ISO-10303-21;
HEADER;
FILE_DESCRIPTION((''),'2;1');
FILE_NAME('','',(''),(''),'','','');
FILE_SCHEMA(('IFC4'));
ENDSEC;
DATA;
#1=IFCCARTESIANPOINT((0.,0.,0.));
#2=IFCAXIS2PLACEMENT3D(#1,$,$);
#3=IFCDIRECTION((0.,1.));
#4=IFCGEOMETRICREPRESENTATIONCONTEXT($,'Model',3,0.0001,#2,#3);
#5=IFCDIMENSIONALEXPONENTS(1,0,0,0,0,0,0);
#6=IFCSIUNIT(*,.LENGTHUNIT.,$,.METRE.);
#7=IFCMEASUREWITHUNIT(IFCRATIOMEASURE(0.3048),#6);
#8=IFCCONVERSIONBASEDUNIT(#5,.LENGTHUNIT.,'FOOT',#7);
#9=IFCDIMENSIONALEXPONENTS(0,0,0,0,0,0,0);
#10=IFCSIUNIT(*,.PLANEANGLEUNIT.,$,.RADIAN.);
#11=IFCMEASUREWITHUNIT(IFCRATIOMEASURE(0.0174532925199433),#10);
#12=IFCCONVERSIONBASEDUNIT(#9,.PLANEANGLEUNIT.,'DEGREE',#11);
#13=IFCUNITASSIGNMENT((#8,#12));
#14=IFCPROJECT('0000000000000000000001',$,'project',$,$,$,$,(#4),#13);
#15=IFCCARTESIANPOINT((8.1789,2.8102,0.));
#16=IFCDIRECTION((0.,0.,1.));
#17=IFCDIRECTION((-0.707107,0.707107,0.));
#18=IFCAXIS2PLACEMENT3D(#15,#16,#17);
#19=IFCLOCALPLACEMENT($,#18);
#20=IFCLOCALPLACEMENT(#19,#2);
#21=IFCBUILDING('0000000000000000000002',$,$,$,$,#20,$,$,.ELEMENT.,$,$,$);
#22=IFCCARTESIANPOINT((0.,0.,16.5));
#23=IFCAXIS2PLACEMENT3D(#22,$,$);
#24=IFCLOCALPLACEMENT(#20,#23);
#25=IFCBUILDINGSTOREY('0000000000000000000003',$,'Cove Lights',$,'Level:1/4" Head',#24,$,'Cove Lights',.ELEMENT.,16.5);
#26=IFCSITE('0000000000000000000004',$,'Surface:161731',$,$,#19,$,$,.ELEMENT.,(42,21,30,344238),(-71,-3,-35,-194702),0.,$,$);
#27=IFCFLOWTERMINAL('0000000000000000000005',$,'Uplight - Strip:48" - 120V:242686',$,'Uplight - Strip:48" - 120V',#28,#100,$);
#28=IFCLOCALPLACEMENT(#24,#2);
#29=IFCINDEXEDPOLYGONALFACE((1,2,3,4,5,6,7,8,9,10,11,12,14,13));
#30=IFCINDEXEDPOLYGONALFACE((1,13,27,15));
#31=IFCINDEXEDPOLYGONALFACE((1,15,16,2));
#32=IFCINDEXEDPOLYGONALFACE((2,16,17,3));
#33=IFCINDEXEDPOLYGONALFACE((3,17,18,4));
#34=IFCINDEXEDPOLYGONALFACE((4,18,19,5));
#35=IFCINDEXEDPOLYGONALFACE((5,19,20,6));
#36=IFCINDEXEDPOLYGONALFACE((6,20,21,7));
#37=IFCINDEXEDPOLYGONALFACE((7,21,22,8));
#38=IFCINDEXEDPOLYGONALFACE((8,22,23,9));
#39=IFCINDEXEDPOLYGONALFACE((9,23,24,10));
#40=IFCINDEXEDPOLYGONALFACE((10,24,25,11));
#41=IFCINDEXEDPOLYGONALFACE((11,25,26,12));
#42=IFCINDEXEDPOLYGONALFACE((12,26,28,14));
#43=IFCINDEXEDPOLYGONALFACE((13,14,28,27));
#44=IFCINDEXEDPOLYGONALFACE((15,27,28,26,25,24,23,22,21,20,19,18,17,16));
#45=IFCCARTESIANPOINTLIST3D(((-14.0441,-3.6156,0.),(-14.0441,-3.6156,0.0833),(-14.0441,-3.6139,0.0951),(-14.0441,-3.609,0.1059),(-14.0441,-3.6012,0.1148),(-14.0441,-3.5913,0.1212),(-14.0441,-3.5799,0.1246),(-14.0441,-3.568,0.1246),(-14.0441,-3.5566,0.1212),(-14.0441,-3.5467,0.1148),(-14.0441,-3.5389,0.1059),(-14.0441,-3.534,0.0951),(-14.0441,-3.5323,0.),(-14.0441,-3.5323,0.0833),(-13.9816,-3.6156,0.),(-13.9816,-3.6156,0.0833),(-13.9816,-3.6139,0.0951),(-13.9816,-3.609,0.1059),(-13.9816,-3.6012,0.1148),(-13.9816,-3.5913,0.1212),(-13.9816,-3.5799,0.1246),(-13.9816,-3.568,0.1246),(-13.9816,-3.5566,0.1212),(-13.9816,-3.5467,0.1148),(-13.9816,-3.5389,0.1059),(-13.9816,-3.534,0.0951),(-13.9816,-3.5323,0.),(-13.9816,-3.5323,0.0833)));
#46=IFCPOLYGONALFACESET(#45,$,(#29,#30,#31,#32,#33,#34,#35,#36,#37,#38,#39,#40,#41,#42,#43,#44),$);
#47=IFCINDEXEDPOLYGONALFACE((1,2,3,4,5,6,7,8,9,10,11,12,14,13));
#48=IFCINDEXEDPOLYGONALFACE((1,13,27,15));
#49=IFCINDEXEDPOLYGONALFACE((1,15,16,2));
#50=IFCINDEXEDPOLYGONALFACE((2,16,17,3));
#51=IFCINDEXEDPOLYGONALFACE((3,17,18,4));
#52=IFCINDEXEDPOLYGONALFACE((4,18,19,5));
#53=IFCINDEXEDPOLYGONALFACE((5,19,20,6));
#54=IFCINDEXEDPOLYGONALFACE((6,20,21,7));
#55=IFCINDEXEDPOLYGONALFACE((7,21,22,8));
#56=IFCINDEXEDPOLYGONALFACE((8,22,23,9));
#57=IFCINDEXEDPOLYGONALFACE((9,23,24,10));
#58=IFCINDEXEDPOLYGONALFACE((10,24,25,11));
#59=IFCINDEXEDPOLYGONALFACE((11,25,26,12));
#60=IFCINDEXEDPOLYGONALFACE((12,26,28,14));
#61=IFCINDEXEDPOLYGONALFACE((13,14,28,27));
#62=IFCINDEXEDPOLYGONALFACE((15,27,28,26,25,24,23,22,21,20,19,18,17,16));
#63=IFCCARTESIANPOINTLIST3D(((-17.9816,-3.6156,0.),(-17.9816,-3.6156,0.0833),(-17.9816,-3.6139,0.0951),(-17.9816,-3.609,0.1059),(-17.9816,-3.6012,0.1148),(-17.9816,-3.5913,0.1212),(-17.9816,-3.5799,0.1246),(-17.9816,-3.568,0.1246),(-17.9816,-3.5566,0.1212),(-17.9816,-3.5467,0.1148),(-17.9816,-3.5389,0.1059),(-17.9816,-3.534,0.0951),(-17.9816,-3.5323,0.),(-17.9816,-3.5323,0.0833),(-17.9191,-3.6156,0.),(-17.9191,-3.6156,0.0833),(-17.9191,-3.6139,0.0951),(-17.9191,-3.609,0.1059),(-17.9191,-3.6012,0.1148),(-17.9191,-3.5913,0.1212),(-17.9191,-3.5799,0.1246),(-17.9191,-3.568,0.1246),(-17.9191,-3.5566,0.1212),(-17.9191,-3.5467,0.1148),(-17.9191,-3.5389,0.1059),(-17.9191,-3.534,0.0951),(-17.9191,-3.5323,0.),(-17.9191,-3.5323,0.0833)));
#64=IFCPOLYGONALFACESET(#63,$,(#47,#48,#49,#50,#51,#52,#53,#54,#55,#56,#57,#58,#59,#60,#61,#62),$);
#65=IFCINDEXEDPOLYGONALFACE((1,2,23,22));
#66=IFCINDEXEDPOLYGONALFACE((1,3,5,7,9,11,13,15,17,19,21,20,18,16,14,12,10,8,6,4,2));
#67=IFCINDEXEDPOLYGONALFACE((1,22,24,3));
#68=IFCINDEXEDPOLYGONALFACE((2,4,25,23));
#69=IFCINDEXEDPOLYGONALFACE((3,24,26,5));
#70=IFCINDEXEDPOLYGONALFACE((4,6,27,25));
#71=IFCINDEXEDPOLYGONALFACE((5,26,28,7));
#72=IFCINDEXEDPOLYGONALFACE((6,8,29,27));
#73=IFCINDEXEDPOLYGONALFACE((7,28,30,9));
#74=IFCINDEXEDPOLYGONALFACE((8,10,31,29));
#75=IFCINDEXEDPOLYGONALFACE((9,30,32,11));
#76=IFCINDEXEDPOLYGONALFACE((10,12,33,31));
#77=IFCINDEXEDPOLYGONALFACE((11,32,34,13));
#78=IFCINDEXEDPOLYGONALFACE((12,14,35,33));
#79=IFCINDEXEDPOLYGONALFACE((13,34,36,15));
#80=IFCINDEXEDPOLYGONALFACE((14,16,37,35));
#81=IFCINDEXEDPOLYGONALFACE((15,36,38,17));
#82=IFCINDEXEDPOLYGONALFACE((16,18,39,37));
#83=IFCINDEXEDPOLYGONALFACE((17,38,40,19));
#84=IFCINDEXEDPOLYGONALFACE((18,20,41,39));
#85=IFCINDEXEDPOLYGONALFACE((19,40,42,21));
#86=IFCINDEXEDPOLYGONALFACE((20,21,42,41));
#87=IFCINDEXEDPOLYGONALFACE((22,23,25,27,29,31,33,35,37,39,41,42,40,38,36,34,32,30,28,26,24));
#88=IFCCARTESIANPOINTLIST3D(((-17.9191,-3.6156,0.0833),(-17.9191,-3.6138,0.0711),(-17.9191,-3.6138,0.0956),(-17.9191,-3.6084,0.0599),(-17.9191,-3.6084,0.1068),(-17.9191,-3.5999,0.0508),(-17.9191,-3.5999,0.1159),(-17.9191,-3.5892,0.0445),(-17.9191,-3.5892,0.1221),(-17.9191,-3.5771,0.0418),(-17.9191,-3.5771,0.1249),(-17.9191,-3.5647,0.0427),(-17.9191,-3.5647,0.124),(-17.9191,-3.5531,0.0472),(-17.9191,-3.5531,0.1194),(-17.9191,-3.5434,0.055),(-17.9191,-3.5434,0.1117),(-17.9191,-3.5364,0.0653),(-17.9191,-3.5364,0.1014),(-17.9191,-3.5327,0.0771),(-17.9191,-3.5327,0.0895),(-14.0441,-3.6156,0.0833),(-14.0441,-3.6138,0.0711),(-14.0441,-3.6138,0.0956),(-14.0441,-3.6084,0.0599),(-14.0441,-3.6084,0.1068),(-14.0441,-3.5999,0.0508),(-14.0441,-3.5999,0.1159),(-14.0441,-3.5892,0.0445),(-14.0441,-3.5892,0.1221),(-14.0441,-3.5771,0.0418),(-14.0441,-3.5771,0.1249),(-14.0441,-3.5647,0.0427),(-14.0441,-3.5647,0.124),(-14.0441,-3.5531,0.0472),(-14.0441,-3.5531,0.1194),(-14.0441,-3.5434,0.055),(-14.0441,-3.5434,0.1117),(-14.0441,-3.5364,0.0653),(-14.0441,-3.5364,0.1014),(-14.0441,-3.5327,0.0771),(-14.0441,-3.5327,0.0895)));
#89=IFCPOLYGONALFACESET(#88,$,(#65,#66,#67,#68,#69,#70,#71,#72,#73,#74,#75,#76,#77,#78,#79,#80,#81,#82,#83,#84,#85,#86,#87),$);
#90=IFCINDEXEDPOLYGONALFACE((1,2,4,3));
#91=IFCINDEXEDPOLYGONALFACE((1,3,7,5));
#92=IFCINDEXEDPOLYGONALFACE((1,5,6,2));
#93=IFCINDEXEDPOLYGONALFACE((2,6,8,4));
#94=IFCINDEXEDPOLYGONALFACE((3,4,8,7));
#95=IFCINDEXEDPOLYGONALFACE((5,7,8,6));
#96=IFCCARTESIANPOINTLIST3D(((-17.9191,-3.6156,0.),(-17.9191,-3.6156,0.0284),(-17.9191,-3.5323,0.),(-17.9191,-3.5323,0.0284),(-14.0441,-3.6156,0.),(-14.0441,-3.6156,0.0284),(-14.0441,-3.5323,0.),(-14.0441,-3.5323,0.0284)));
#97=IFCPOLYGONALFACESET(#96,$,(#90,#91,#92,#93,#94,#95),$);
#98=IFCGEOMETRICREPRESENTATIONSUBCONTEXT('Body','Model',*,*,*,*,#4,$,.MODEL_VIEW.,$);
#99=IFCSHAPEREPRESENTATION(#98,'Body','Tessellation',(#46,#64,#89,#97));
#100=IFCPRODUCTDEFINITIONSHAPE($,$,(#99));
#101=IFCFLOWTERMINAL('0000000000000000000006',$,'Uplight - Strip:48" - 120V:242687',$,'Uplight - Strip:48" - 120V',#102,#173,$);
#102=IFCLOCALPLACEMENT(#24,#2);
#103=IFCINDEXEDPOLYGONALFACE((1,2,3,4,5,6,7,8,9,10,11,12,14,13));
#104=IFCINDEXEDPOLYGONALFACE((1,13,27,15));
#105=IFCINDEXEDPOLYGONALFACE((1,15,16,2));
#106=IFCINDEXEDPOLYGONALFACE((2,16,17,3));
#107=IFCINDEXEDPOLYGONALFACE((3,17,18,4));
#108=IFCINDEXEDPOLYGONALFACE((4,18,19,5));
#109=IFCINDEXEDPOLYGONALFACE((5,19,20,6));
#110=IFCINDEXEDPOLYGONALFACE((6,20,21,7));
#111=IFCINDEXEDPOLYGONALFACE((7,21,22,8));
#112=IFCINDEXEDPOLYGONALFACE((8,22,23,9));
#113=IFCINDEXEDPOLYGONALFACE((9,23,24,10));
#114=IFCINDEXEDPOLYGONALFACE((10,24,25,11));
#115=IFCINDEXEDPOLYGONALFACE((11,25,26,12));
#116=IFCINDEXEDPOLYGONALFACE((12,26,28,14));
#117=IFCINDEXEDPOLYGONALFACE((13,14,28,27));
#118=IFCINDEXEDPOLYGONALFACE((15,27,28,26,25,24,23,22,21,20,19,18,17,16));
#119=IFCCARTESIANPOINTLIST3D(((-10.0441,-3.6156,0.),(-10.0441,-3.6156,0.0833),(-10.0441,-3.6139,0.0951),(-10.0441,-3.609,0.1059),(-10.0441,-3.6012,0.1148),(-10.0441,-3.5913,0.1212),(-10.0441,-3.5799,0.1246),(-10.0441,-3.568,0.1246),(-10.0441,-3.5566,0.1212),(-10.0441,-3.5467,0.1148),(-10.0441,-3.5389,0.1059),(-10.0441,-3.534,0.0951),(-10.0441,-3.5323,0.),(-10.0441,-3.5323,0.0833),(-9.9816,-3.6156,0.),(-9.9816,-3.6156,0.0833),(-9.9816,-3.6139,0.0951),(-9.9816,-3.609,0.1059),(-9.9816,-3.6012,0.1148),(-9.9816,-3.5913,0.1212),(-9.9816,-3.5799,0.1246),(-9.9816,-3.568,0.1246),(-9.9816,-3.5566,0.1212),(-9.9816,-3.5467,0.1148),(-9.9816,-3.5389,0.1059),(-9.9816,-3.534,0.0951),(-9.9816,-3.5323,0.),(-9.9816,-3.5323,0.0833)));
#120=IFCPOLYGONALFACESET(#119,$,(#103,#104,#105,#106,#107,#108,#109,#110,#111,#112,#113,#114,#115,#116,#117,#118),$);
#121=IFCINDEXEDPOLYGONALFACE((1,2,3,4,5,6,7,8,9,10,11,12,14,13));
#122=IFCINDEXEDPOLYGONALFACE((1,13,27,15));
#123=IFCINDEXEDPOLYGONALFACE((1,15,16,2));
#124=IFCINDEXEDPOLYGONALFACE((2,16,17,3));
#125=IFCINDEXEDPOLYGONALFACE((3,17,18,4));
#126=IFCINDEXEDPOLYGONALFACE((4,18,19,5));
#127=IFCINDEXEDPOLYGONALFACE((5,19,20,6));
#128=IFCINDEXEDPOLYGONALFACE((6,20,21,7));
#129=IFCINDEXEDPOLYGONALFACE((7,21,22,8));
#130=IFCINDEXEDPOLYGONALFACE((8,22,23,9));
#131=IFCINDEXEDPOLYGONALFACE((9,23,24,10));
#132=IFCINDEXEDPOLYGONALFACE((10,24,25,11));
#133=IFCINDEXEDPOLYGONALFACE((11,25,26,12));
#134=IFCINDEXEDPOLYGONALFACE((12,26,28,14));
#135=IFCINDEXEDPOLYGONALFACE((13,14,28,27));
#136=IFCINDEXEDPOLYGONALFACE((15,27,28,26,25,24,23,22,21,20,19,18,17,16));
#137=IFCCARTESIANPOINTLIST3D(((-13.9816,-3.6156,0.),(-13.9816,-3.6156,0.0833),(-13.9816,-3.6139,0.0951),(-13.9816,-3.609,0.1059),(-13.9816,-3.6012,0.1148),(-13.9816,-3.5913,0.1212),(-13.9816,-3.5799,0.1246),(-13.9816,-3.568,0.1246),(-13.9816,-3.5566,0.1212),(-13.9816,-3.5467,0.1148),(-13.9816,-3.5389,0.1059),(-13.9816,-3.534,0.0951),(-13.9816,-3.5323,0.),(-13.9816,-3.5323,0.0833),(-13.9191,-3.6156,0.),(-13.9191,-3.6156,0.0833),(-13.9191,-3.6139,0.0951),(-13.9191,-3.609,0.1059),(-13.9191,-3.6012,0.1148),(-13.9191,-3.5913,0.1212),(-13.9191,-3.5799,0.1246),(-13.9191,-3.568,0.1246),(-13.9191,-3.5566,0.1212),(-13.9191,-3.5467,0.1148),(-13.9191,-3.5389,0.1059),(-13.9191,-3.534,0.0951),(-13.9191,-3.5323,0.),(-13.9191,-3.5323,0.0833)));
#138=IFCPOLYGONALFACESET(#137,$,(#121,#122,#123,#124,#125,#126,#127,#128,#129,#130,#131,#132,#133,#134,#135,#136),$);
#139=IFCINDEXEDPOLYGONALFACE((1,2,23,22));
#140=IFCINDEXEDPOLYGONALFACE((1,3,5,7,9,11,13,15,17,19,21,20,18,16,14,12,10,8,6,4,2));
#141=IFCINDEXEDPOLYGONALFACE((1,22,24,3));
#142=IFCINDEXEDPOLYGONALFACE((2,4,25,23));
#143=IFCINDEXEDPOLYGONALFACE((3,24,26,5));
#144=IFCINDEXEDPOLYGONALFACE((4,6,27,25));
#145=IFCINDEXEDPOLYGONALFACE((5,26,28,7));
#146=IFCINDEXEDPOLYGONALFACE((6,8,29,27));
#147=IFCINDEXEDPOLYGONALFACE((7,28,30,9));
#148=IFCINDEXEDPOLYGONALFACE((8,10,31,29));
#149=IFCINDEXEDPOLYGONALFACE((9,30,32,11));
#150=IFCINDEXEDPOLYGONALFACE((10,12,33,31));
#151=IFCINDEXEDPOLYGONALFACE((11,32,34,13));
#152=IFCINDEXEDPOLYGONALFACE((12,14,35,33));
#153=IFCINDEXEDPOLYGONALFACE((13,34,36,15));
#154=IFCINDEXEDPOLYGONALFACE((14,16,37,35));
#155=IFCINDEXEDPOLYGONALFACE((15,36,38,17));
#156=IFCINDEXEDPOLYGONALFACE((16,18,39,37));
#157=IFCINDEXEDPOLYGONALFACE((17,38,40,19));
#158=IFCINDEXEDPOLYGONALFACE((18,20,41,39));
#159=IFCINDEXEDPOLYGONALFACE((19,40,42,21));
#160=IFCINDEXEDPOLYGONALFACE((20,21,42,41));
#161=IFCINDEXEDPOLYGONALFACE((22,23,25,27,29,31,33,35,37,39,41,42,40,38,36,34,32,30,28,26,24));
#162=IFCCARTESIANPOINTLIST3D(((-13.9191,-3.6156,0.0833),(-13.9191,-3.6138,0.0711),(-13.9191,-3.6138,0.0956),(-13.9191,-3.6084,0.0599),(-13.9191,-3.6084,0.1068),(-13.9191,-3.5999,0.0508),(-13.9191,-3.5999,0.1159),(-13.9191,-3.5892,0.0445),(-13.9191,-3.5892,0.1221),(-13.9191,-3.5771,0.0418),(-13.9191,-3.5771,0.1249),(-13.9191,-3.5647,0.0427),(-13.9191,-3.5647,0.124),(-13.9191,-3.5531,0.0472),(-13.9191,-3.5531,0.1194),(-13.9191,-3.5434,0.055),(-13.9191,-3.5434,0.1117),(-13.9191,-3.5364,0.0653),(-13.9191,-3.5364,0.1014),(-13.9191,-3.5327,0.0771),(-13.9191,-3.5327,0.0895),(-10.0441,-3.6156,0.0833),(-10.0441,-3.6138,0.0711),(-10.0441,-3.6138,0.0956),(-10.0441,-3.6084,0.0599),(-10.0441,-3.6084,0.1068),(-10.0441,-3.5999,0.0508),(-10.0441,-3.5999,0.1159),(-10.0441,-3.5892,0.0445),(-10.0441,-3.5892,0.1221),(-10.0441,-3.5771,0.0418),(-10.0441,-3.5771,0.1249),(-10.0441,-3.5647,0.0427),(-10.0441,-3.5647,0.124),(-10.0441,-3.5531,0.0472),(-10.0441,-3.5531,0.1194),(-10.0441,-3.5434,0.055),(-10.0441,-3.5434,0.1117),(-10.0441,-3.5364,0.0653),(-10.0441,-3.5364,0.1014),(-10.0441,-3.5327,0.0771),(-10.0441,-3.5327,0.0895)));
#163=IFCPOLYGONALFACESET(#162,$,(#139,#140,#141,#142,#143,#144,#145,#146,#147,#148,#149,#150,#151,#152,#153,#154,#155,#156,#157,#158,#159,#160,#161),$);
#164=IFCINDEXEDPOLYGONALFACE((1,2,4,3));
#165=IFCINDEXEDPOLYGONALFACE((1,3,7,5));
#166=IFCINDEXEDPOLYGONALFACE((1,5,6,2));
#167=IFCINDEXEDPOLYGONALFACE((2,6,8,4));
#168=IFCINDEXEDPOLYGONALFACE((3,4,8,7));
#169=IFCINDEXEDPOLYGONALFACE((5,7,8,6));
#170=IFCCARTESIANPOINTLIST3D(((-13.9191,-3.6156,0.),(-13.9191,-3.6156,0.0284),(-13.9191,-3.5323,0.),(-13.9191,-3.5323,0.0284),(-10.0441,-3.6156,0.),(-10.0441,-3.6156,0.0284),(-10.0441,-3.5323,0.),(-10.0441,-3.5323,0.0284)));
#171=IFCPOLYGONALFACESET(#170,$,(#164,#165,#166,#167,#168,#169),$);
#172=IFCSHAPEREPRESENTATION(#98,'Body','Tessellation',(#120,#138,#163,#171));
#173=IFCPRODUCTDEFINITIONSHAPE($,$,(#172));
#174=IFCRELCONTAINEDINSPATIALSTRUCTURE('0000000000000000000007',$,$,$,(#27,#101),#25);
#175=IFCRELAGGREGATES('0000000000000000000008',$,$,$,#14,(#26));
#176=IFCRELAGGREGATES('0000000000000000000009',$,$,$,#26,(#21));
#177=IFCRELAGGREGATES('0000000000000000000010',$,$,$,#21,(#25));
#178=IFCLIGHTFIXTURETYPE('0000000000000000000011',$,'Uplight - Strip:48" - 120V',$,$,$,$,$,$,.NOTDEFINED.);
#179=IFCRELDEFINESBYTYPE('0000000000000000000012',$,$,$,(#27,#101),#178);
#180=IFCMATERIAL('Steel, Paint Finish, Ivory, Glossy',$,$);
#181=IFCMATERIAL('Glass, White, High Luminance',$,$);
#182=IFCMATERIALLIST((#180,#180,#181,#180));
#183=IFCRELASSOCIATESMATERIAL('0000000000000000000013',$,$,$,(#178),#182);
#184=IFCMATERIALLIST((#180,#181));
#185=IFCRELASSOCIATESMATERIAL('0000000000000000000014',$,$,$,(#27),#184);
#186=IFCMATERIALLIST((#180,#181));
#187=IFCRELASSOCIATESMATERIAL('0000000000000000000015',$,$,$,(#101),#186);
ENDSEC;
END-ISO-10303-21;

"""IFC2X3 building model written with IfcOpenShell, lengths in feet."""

from ifc_helpers import new_model, entity, si_unit, converted_unit, direction, frame, frame_2d, origin, origin_2d_with_axis, place, context, subcontext, project, spatial, polyline, circle_curve, parameter, trimmed, segment, composite_curve, rectangle, circle, outline, extrude, source, transform, mapped, material, material_list, type_object, type_shapes, element, save


model = new_model("IFC2X3")

# Units and contexts
model_context = context("Model", 3, precision=0.0001, world=origin(), true_north=direction((0.0, 1.0)))
body_context = subcontext(model_context, "Body", "Model", "MODEL_VIEW")
ifc_project = project(units=[converted_unit("LENGTHUNIT", "FOOT", entity("IfcRatioMeasure", 0.3048), si_unit("LENGTHUNIT", "METRE"), dimensions=[1, 0, 0, 0, 0, 0, 0]), converted_unit("PLANEANGLEUNIT", "DEGREE", entity("IfcRatioMeasure", 0.0174532925199433), si_unit("PLANEANGLEUNIT", "RADIAN"), dimensions=[0, 0, 0, 0, 0, 0, 0])], contexts=[model_context])

# Site, building, storey
site_placement = place(None, frame((8.1789, 2.8102, 0.0), z_axis=(0.0, 0.0, 1.0), x_axis=(-0.707107, 0.707107, 0.0)))
site = spatial("IfcSite", under=ifc_project, at=site_placement, Name="Surface:161731", CompositionType="ELEMENT", RefLatitude=(42, 21, 30, 344238), RefLongitude=(-71, -3, -35, -194702), RefElevation=0.0)
building_placement = place(site_placement, origin())
building = spatial("IfcBuilding", under=site, at=building_placement, CompositionType="ELEMENT")
storey_placement = place(building_placement, frame((0.0, 0.0, 16.5)))
storey = spatial("IfcBuildingStorey", under=building, at=storey_placement, Name="Cove Lights", ObjectType="Level:1/4\" Head", LongName="Cove Lights", CompositionType="ELEMENT", Elevation=16.5)

# Flow terminals
ifc_material_1 = material(Name="Steel, Paint Finish, Ivory, Glossy")
ifc_material_2 = material(Name="Glass, White, High Luminance")
ifc_material_list_1 = material_list([ifc_material_1, ifc_material_1, ifc_material_2, ifc_material_1])
light_fixture_type_1 = type_object("IfcLightFixtureType", Name="Uplight - Strip:48\" - 120V", PredefinedType="NOTDEFINED", material=ifc_material_list_1)
shared_shape_1 = source(origin(), body_context, "Body", "SweptSolid", [
    extrude(outline(composite_curve([segment(polyline([(-0.0417, -0.0417), (0.0417, -0.0417)]), True, "CONTINUOUS"), segment(polyline([(0.0417, -0.0417), (0.0417, 0.0417)]), True, "CONTINUOUS"), segment(trimmed(circle_curve(frame_2d((0.0, 0.0417), x_axis=(-1.0, 0.0)), 0.0417), [parameter(180.0)], [parameter(0.0)], True, "PARAMETER"), True, "CONTINUOUS"), segment(polyline([(-0.0417, 0.0417), (-0.0417, -0.0417)]), True, "CONTINUOUS")], self_intersect=False)), frame((1.9375, 0.0, 0.0417), z_axis=(1.0, 0.0, 0.0), x_axis=(0.0, 1.0, 0.0)), (0.0, 0.0, 1.0), 0.0625),
    extrude(outline(composite_curve([segment(polyline([(-0.0417, -0.0417), (0.0417, -0.0417)]), True, "CONTINUOUS"), segment(trimmed(circle_curve(frame_2d((0.0417, 0.0), x_axis=(1.0, 0.0)), 0.0417), [parameter(270.0)], [parameter(90.0)], True, "PARAMETER"), True, "CONTINUOUS"), segment(polyline([(0.0417, 0.0417), (-0.0417, 0.0417)]), True, "CONTINUOUS"), segment(polyline([(-0.0417, 0.0417), (-0.0417, -0.0417)]), True, "CONTINUOUS")], self_intersect=False)), frame((-2.0, 0.0, 0.0417), z_axis=(1.0, 0.0, 0.0), x_axis=(0.0, 0.0, 1.0)), (0.0, 0.0, 1.0), 0.0625),
    extrude(circle(Radius=0.0417, at=frame_2d((0.0, 0.0), x_axis=(1.0, 0.0))), frame((-1.9375, 0.0, 0.0833), z_axis=(1.0, 0.0, 0.0), x_axis=(0.0, -1.0, 0.0)), (0.0, 0.0, 1.0), 3.875),
    extrude(rectangle(XDim=0.0833, YDim=3.875, at=origin_2d_with_axis()), frame((0.0, 0.0, 0.0), z_axis=(0.0, 0.0, 1.0), x_axis=(0.0, 1.0, 0.0)), (0.0, 0.0, 1.0), 0.0284),
])
type_shapes(light_fixture_type_1, [shared_shape_1])
ifc_material_list_2 = material_list([ifc_material_1, ifc_material_2])
flow_terminal_1_placement = place(storey_placement, frame((-15.9816, -3.5739, 0.0)))
element("IfcFlowTerminal", 1, at=flow_terminal_1_placement, inside=storey, type_object=light_fixture_type_1, material=ifc_material_list_2, Name="Uplight - Strip:48\" - 120V:242686", ObjectType="Uplight - Strip:48\" - 120V", context=body_context, shape_type="MappedRepresentation", body=[
    mapped(shared_shape_1, transform((0.0, 0.0, 0.0), scale=1.0)),
])
ifc_material_list_3 = material_list([ifc_material_1, ifc_material_2])
flow_terminal_2_placement = place(storey_placement, frame((-11.9816, -3.5739, 0.0)))
element("IfcFlowTerminal", 2, at=flow_terminal_2_placement, inside=storey, type_object=light_fixture_type_1, material=ifc_material_list_3, Name="Uplight - Strip:48\" - 120V:242687", ObjectType="Uplight - Strip:48\" - 120V", context=body_context, shape_type="MappedRepresentation", body=[
    mapped(shared_shape_1, transform((0.0, 0.0, 0.0), scale=1.0)),
])

save(model, "model.ifc")
